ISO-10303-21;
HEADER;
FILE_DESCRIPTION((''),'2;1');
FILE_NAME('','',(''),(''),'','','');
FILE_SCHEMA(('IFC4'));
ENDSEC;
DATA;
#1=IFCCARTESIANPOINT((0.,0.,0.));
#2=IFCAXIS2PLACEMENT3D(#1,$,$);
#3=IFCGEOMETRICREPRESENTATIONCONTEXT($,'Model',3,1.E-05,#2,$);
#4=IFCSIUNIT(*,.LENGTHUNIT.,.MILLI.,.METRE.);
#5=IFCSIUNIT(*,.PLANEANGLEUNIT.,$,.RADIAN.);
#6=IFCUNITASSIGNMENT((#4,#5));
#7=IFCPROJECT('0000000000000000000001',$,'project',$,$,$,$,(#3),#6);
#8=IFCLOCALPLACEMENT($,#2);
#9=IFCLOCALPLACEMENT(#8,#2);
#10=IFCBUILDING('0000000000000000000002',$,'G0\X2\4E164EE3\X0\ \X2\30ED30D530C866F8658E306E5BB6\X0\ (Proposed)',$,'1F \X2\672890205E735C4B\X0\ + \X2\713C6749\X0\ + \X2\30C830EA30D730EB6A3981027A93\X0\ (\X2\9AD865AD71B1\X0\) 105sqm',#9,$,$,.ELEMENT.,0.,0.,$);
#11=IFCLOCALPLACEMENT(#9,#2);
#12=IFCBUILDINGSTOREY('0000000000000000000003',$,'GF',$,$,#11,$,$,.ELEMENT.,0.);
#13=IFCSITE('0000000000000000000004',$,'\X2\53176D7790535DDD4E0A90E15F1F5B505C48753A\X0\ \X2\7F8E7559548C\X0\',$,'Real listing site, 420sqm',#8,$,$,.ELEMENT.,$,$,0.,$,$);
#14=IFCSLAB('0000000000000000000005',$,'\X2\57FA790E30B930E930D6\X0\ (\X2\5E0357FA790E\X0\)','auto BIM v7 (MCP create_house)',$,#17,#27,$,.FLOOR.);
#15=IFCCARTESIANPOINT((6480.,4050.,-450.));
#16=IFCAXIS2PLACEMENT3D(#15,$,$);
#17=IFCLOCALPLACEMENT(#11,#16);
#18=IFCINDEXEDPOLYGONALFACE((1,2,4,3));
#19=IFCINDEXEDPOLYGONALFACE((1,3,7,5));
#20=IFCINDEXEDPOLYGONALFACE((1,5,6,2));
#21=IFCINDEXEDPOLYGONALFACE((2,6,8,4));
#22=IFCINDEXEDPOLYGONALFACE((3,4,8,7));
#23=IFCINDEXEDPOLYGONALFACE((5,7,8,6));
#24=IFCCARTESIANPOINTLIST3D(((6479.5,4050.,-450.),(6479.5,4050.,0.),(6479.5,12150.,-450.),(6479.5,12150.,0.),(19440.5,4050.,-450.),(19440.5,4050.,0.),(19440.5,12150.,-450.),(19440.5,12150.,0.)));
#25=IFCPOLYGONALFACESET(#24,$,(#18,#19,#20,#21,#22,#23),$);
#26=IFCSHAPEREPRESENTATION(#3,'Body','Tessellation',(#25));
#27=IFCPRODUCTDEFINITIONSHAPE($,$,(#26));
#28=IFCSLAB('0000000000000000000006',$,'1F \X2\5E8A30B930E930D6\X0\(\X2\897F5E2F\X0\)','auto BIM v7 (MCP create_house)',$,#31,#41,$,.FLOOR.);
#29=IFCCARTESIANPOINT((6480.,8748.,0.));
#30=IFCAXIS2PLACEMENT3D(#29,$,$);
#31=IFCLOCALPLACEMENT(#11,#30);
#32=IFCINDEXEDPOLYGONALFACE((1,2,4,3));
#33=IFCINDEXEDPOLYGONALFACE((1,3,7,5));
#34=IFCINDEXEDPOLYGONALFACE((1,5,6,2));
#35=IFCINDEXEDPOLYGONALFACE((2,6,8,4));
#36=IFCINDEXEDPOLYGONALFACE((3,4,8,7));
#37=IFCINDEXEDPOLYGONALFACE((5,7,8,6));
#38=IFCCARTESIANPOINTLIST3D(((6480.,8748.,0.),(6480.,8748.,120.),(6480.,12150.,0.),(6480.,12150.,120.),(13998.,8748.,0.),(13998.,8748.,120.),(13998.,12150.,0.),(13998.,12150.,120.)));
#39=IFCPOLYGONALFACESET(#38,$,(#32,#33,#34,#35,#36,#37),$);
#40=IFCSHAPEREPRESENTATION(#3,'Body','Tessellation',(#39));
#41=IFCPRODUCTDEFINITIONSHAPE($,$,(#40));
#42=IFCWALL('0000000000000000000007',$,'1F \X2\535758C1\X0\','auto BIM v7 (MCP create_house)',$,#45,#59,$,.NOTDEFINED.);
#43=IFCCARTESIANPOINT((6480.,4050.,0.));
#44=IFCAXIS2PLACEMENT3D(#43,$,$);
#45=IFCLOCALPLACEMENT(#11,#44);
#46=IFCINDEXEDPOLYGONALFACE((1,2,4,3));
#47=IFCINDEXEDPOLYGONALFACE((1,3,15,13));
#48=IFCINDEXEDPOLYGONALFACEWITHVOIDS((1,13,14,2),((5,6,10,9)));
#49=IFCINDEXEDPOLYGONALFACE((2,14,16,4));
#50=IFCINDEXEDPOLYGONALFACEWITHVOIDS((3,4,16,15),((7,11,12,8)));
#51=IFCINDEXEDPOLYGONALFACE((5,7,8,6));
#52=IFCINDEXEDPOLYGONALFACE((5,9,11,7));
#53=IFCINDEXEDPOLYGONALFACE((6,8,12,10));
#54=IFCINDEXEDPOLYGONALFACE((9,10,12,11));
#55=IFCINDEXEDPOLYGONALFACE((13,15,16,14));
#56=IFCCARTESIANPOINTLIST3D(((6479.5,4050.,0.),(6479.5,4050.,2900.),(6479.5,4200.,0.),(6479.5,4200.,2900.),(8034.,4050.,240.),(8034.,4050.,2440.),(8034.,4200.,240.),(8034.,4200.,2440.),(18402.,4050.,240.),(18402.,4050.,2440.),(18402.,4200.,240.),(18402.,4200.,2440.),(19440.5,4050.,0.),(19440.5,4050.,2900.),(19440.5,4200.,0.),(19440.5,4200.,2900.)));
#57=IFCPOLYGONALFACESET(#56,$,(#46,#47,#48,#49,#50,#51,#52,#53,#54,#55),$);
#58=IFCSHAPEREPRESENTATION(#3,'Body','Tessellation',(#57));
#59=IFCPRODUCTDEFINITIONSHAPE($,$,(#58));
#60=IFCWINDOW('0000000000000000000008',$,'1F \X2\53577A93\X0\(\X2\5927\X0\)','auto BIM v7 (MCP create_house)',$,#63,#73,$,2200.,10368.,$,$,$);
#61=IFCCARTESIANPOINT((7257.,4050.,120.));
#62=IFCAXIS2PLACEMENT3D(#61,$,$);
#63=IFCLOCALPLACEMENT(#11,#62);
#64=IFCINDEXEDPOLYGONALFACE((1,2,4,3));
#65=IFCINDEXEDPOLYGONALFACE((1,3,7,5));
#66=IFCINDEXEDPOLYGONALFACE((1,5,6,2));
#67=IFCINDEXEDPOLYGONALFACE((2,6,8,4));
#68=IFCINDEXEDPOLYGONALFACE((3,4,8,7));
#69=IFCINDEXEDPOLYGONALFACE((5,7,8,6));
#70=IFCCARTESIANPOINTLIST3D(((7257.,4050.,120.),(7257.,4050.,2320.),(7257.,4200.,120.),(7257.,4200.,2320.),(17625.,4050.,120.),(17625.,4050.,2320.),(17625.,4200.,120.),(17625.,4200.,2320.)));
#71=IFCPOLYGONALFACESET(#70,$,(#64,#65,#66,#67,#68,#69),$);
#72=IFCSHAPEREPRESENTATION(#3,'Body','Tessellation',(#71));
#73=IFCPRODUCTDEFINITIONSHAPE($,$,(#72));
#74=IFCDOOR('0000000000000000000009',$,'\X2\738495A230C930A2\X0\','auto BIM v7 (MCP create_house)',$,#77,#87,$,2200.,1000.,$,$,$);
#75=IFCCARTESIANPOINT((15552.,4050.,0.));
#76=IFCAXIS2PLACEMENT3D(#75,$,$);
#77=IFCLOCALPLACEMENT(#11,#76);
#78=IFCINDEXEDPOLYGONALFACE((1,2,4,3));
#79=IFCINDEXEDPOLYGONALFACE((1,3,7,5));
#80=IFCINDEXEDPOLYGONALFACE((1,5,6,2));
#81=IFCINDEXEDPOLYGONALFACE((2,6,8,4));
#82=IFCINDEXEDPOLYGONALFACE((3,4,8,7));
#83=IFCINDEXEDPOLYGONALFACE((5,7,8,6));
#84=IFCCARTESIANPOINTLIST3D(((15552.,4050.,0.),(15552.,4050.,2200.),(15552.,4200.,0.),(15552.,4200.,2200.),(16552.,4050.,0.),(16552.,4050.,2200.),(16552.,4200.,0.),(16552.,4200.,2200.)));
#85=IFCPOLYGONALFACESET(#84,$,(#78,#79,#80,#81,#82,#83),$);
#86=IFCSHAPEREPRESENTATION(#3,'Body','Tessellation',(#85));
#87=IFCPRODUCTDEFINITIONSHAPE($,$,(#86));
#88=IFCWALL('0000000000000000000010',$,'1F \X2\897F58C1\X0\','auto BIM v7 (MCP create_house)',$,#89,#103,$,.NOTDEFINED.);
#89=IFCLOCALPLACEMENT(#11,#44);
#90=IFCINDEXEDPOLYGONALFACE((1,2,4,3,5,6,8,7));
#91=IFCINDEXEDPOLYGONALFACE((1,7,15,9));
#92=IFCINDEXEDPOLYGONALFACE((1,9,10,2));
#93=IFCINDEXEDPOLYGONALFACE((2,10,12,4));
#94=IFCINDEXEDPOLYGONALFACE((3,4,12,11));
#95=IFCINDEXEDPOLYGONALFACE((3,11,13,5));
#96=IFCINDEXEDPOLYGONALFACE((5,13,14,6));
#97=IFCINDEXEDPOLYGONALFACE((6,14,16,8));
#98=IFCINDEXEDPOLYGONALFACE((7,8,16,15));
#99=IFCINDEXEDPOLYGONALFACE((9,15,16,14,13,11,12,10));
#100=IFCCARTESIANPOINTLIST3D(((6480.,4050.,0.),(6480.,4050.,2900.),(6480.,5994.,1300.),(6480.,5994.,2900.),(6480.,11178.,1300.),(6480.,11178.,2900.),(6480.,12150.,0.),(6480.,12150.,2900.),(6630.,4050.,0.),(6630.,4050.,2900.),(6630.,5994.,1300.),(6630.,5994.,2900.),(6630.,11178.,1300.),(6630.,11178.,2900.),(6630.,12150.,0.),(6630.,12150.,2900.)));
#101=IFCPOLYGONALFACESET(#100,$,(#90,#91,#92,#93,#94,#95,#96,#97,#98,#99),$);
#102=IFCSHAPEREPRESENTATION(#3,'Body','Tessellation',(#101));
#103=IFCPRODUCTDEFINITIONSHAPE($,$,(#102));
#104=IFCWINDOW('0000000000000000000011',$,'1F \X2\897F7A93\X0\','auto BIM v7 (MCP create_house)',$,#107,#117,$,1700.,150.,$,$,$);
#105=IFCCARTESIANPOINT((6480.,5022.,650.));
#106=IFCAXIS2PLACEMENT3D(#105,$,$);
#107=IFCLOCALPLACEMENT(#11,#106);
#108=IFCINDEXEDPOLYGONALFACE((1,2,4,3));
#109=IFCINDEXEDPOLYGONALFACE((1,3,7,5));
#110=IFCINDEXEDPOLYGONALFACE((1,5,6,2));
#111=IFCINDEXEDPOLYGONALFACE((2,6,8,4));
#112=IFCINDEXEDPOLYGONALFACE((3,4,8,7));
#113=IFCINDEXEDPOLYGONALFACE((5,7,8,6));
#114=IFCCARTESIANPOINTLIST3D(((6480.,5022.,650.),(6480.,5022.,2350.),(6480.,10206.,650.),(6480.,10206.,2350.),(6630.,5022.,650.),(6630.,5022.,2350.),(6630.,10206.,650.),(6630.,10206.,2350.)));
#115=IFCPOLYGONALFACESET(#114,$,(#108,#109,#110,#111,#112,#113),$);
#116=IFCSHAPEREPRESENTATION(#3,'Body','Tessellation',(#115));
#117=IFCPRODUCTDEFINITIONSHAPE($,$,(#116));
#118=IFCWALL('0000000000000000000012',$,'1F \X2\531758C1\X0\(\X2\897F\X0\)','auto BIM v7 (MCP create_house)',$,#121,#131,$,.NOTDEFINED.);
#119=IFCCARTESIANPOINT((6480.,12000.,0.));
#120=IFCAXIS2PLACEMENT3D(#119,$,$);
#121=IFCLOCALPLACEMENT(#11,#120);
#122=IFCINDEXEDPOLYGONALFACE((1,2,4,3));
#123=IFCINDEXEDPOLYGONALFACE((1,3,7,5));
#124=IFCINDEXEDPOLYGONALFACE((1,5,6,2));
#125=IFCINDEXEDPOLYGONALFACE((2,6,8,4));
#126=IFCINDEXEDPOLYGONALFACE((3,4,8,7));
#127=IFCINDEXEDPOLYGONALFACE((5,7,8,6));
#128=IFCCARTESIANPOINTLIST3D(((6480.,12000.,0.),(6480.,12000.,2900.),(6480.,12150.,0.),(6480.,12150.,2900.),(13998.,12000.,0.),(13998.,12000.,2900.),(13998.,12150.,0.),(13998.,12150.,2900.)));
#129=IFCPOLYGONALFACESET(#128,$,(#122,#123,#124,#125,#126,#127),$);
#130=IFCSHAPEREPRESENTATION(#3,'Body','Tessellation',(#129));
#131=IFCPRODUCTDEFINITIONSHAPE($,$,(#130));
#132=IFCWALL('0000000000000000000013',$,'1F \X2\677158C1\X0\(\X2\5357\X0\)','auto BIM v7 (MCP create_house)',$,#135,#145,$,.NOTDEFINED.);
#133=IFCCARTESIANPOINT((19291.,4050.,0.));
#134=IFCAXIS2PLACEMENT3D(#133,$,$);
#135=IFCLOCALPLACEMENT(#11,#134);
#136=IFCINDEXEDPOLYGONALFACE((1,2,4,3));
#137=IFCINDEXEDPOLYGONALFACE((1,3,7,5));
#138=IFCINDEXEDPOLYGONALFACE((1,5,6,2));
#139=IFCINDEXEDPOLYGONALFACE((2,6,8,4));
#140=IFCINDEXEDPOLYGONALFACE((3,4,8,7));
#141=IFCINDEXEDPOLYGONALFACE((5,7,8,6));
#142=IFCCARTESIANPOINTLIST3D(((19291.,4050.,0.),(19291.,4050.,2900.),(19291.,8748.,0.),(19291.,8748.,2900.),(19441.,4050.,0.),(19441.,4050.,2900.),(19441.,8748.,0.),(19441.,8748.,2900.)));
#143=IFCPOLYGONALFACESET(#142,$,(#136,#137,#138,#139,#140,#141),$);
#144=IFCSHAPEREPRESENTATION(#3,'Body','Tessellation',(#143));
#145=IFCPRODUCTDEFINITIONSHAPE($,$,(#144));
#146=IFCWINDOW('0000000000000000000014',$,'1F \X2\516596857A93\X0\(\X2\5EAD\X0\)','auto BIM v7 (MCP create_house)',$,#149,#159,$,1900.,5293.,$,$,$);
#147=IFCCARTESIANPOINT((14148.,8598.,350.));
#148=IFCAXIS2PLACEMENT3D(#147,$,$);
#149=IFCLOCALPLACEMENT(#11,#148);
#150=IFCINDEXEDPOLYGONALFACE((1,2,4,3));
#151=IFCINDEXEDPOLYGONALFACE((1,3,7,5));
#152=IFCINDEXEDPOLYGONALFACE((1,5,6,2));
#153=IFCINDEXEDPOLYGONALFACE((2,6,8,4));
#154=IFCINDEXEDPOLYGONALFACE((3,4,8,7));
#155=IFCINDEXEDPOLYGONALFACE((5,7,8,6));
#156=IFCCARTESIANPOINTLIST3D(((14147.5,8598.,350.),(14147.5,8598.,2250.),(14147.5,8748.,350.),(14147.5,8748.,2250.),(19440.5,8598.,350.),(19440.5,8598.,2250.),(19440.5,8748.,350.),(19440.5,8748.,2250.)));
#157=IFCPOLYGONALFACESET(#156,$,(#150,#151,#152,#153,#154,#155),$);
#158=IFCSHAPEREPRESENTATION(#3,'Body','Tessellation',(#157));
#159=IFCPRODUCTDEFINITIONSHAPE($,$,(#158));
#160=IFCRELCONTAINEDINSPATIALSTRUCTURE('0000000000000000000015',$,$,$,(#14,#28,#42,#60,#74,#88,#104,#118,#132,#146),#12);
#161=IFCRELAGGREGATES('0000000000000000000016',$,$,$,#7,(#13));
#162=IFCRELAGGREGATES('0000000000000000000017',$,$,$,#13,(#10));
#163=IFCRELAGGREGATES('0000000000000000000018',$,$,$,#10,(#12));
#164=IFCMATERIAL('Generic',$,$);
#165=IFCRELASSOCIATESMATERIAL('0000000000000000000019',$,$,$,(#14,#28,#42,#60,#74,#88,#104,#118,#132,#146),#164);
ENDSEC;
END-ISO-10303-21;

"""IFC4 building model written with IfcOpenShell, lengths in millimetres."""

from ifc_helpers import new_model, si_unit, frame, frame_2d, origin, place, context, project, spatial, rectangle, extrude, material, element, fill, save


model = new_model("IFC4")

# Units and contexts
model_context = context("Model", 3, precision=1e-05, world=origin())
ifc_project = project(units=[si_unit("LENGTHUNIT", "METRE", prefix="MILLI"), si_unit("PLANEANGLEUNIT", "RADIAN")], contexts=[model_context])

# Site, building, storey
site_placement = place(None, origin())
site = spatial("IfcSite", under=ifc_project, at=site_placement, Name="北海道川上郡弟子屈町 美留和", ObjectType="Real listing site, 420sqm", CompositionType="ELEMENT", RefElevation=0.0)
building_placement = place(site_placement, origin())
building = spatial("IfcBuilding", under=site, at=building_placement, Name="G0世代 ロフト書斎の家 (Proposed)", ObjectType="1F 木造平屋 + 焼杉 + トリプル樹脂窓 (高断熱) 105sqm", CompositionType="ELEMENT", ElevationOfRefHeight=0.0, ElevationOfTerrain=0.0)
storey_placement = place(building_placement, origin())
storey = spatial("IfcBuildingStorey", under=building, at=storey_placement, Name="GF", CompositionType="ELEMENT", Elevation=0.0)

# Slabs
ifc_material = material(Name="Generic")
slab_1_placement = place(storey_placement, frame((6480.0, 4050.0, -450.0)))
element("IfcSlab", 1, at=slab_1_placement, inside=storey, material=ifc_material, Name="基礎スラブ (布基礎)", Description="auto BIM v7 (MCP create_house)", PredefinedType="FLOOR", context=model_context, shape_type="SweptSolid", body=[
    extrude(rectangle(XDim=12961.0, YDim=8100.0, at=frame_2d((6480.0, 4050.0))), frame((6480.0, 4050.0, -450.0)), (0.0, 0.0, 1.0), 450.0),
])
slab_2_placement = place(storey_placement, frame((6480.0, 8748.0, 0.0)))
element("IfcSlab", 2, at=slab_2_placement, inside=storey, material=ifc_material, Name="1F 床スラブ(西帯)", Description="auto BIM v7 (MCP create_house)", PredefinedType="FLOOR", context=model_context, shape_type="SweptSolid", body=[
    extrude(rectangle(XDim=7518.0, YDim=3402.0, at=frame_2d((3759.0, 1701.0))), frame((6480.0, 8748.0, 0.0)), (0.0, 0.0, 1.0), 120.0),
])

# Wall, openings, window, door
wall_1_placement = place(storey_placement, frame((6480.0, 4050.0, 0.0)))
wall_1 = element("IfcWall", 3, at=wall_1_placement, inside=storey, material=ifc_material, Name="1F 南壁", Description="auto BIM v7 (MCP create_house)", PredefinedType="NOTDEFINED", context=model_context, shape_type="SweptSolid", body=[
    extrude(rectangle(XDim=12961.0, YDim=150.0, at=frame_2d((6480.0, 75.0))), frame((6480.0, 4050.0, 0.0)), (0.0, 0.0, 1.0), 2900.0),
])
opening_1_placement = place(storey_placement, frame((7257.0, 4050.0, 120.0)))
opening_1 = element("IfcOpeningElement", 4, at=opening_1_placement, cuts=wall_1, PredefinedType="NOTDEFINED", context=model_context, shape_type="SweptSolid", body=[
    extrude(rectangle(XDim=10368.0, YDim=150.0, at=frame_2d((5184.0, 75.0))), frame((7257.0, 4050.0, 120.0)), (0.0, 0.0, 1.0), 2200.0),
])
opening_2_placement = place(storey_placement, frame((15552.0, 4050.0, 0.0)))
opening_2 = element("IfcOpeningElement", 5, at=opening_2_placement, cuts=wall_1, PredefinedType="NOTDEFINED", context=model_context, shape_type="SweptSolid", body=[
    extrude(rectangle(XDim=1000.0, YDim=150.0, at=frame_2d((500.0, 75.0))), frame((15552.0, 4050.0, 0.0)), (0.0, 0.0, 1.0), 2200.0),
])
window_1_placement = place(storey_placement, frame((7257.0, 4050.0, 120.0)))
window_1 = element("IfcWindow", 6, at=window_1_placement, inside=storey, material=ifc_material, Name="1F 南窓(大)", Description="auto BIM v7 (MCP create_house)", OverallHeight=2200.0, OverallWidth=10368.0, context=model_context, shape_type="SweptSolid", body=[
    extrude(rectangle(XDim=10368.0, YDim=150.0, at=frame_2d((5184.0, 75.0))), frame((7257.0, 4050.0, 120.0)), (0.0, 0.0, 1.0), 2200.0),
])
fill(opening_1, window_1)
door_placement = place(storey_placement, frame((15552.0, 4050.0, 0.0)))
door = element("IfcDoor", 7, at=door_placement, inside=storey, material=ifc_material, Name="玄関ドア", Description="auto BIM v7 (MCP create_house)", OverallHeight=2200.0, OverallWidth=1000.0, context=model_context, shape_type="SweptSolid", body=[
    extrude(rectangle(XDim=1000.0, YDim=150.0, at=frame_2d((500.0, 75.0))), frame((15552.0, 4050.0, 0.0)), (0.0, 0.0, 1.0), 2200.0),
])
fill(opening_2, door)

# Wall, opening, window
wall_2_placement = place(storey_placement, frame((6480.0, 4050.0, 0.0)))
wall_2 = element("IfcWall", 8, at=wall_2_placement, inside=storey, material=ifc_material, Name="1F 西壁", Description="auto BIM v7 (MCP create_house)", PredefinedType="NOTDEFINED", context=model_context, shape_type="SweptSolid", body=[
    extrude(rectangle(XDim=150.0, YDim=8100.0, at=frame_2d((75.0, 4050.0))), frame((6480.0, 4050.0, 0.0)), (0.0, 0.0, 1.0), 2900.0),
])
opening_3_placement = place(storey_placement, frame((6480.0, 5022.0, 650.0)))
opening_3 = element("IfcOpeningElement", 9, at=opening_3_placement, cuts=wall_2, PredefinedType="NOTDEFINED", context=model_context, shape_type="SweptSolid", body=[
    extrude(rectangle(XDim=150.0, YDim=5184.0, at=frame_2d((75.0, 2592.0))), frame((6480.0, 5022.0, 650.0)), (0.0, 0.0, 1.0), 1700.0),
])
window_2_placement = place(storey_placement, frame((6480.0, 5022.0, 650.0)))
window_2 = element("IfcWindow", 10, at=window_2_placement, inside=storey, material=ifc_material, Name="1F 西窓", Description="auto BIM v7 (MCP create_house)", OverallHeight=1700.0, OverallWidth=150.0, context=model_context, shape_type="SweptSolid", body=[
    extrude(rectangle(XDim=150.0, YDim=5184.0, at=frame_2d((75.0, 2592.0))), frame((6480.0, 5022.0, 650.0)), (0.0, 0.0, 1.0), 1700.0),
])
fill(opening_3, window_2)

# Wall
wall_3_placement = place(storey_placement, frame((6480.0, 12000.0, 0.0)))
element("IfcWall", 11, at=wall_3_placement, inside=storey, material=ifc_material, Name="1F 北壁(西)", Description="auto BIM v7 (MCP create_house)", PredefinedType="NOTDEFINED", context=model_context, shape_type="SweptSolid", body=[
    extrude(rectangle(XDim=7518.0, YDim=150.0, at=frame_2d((3759.0, 75.0))), frame((6480.0, 12000.0, 0.0)), (0.0, 0.0, 1.0), 2900.0),
])

# Wall, opening, window
wall_4_placement = place(storey_placement, frame((19291.0, 4050.0, 0.0)))
wall_4 = element("IfcWall", 12, at=wall_4_placement, inside=storey, material=ifc_material, Name="1F 東壁(南)", Description="auto BIM v7 (MCP create_house)", PredefinedType="NOTDEFINED", context=model_context, shape_type="SweptSolid", body=[
    extrude(rectangle(XDim=150.0, YDim=4698.0, at=frame_2d((75.0, 2349.0))), frame((19291.0, 4050.0, 0.0)), (0.0, 0.0, 1.0), 2900.0),
])
opening_4_placement = place(storey_placement, frame((14148.0, 8598.0, 350.0)))
opening_4 = element("IfcOpeningElement", 13, at=opening_4_placement, cuts=wall_4, PredefinedType="NOTDEFINED", context=model_context, shape_type="SweptSolid", body=[
    extrude(rectangle(XDim=5293.0, YDim=150.0, at=frame_2d((2646.0, 75.0))), frame((14148.0, 8598.0, 350.0)), (0.0, 0.0, 1.0), 1900.0),
])
window_3_placement = place(storey_placement, frame((14148.0, 8598.0, 350.0)))
window_3 = element("IfcWindow", 14, at=window_3_placement, inside=storey, material=ifc_material, Name="1F 入隅窓(庭)", Description="auto BIM v7 (MCP create_house)", OverallHeight=1900.0, OverallWidth=5293.0, context=model_context, shape_type="SweptSolid", body=[
    extrude(rectangle(XDim=5293.0, YDim=150.0, at=frame_2d((2646.0, 75.0))), frame((14148.0, 8598.0, 350.0)), (0.0, 0.0, 1.0), 1900.0),
])
fill(opening_4, window_3)

save(model, "model.ifc")
